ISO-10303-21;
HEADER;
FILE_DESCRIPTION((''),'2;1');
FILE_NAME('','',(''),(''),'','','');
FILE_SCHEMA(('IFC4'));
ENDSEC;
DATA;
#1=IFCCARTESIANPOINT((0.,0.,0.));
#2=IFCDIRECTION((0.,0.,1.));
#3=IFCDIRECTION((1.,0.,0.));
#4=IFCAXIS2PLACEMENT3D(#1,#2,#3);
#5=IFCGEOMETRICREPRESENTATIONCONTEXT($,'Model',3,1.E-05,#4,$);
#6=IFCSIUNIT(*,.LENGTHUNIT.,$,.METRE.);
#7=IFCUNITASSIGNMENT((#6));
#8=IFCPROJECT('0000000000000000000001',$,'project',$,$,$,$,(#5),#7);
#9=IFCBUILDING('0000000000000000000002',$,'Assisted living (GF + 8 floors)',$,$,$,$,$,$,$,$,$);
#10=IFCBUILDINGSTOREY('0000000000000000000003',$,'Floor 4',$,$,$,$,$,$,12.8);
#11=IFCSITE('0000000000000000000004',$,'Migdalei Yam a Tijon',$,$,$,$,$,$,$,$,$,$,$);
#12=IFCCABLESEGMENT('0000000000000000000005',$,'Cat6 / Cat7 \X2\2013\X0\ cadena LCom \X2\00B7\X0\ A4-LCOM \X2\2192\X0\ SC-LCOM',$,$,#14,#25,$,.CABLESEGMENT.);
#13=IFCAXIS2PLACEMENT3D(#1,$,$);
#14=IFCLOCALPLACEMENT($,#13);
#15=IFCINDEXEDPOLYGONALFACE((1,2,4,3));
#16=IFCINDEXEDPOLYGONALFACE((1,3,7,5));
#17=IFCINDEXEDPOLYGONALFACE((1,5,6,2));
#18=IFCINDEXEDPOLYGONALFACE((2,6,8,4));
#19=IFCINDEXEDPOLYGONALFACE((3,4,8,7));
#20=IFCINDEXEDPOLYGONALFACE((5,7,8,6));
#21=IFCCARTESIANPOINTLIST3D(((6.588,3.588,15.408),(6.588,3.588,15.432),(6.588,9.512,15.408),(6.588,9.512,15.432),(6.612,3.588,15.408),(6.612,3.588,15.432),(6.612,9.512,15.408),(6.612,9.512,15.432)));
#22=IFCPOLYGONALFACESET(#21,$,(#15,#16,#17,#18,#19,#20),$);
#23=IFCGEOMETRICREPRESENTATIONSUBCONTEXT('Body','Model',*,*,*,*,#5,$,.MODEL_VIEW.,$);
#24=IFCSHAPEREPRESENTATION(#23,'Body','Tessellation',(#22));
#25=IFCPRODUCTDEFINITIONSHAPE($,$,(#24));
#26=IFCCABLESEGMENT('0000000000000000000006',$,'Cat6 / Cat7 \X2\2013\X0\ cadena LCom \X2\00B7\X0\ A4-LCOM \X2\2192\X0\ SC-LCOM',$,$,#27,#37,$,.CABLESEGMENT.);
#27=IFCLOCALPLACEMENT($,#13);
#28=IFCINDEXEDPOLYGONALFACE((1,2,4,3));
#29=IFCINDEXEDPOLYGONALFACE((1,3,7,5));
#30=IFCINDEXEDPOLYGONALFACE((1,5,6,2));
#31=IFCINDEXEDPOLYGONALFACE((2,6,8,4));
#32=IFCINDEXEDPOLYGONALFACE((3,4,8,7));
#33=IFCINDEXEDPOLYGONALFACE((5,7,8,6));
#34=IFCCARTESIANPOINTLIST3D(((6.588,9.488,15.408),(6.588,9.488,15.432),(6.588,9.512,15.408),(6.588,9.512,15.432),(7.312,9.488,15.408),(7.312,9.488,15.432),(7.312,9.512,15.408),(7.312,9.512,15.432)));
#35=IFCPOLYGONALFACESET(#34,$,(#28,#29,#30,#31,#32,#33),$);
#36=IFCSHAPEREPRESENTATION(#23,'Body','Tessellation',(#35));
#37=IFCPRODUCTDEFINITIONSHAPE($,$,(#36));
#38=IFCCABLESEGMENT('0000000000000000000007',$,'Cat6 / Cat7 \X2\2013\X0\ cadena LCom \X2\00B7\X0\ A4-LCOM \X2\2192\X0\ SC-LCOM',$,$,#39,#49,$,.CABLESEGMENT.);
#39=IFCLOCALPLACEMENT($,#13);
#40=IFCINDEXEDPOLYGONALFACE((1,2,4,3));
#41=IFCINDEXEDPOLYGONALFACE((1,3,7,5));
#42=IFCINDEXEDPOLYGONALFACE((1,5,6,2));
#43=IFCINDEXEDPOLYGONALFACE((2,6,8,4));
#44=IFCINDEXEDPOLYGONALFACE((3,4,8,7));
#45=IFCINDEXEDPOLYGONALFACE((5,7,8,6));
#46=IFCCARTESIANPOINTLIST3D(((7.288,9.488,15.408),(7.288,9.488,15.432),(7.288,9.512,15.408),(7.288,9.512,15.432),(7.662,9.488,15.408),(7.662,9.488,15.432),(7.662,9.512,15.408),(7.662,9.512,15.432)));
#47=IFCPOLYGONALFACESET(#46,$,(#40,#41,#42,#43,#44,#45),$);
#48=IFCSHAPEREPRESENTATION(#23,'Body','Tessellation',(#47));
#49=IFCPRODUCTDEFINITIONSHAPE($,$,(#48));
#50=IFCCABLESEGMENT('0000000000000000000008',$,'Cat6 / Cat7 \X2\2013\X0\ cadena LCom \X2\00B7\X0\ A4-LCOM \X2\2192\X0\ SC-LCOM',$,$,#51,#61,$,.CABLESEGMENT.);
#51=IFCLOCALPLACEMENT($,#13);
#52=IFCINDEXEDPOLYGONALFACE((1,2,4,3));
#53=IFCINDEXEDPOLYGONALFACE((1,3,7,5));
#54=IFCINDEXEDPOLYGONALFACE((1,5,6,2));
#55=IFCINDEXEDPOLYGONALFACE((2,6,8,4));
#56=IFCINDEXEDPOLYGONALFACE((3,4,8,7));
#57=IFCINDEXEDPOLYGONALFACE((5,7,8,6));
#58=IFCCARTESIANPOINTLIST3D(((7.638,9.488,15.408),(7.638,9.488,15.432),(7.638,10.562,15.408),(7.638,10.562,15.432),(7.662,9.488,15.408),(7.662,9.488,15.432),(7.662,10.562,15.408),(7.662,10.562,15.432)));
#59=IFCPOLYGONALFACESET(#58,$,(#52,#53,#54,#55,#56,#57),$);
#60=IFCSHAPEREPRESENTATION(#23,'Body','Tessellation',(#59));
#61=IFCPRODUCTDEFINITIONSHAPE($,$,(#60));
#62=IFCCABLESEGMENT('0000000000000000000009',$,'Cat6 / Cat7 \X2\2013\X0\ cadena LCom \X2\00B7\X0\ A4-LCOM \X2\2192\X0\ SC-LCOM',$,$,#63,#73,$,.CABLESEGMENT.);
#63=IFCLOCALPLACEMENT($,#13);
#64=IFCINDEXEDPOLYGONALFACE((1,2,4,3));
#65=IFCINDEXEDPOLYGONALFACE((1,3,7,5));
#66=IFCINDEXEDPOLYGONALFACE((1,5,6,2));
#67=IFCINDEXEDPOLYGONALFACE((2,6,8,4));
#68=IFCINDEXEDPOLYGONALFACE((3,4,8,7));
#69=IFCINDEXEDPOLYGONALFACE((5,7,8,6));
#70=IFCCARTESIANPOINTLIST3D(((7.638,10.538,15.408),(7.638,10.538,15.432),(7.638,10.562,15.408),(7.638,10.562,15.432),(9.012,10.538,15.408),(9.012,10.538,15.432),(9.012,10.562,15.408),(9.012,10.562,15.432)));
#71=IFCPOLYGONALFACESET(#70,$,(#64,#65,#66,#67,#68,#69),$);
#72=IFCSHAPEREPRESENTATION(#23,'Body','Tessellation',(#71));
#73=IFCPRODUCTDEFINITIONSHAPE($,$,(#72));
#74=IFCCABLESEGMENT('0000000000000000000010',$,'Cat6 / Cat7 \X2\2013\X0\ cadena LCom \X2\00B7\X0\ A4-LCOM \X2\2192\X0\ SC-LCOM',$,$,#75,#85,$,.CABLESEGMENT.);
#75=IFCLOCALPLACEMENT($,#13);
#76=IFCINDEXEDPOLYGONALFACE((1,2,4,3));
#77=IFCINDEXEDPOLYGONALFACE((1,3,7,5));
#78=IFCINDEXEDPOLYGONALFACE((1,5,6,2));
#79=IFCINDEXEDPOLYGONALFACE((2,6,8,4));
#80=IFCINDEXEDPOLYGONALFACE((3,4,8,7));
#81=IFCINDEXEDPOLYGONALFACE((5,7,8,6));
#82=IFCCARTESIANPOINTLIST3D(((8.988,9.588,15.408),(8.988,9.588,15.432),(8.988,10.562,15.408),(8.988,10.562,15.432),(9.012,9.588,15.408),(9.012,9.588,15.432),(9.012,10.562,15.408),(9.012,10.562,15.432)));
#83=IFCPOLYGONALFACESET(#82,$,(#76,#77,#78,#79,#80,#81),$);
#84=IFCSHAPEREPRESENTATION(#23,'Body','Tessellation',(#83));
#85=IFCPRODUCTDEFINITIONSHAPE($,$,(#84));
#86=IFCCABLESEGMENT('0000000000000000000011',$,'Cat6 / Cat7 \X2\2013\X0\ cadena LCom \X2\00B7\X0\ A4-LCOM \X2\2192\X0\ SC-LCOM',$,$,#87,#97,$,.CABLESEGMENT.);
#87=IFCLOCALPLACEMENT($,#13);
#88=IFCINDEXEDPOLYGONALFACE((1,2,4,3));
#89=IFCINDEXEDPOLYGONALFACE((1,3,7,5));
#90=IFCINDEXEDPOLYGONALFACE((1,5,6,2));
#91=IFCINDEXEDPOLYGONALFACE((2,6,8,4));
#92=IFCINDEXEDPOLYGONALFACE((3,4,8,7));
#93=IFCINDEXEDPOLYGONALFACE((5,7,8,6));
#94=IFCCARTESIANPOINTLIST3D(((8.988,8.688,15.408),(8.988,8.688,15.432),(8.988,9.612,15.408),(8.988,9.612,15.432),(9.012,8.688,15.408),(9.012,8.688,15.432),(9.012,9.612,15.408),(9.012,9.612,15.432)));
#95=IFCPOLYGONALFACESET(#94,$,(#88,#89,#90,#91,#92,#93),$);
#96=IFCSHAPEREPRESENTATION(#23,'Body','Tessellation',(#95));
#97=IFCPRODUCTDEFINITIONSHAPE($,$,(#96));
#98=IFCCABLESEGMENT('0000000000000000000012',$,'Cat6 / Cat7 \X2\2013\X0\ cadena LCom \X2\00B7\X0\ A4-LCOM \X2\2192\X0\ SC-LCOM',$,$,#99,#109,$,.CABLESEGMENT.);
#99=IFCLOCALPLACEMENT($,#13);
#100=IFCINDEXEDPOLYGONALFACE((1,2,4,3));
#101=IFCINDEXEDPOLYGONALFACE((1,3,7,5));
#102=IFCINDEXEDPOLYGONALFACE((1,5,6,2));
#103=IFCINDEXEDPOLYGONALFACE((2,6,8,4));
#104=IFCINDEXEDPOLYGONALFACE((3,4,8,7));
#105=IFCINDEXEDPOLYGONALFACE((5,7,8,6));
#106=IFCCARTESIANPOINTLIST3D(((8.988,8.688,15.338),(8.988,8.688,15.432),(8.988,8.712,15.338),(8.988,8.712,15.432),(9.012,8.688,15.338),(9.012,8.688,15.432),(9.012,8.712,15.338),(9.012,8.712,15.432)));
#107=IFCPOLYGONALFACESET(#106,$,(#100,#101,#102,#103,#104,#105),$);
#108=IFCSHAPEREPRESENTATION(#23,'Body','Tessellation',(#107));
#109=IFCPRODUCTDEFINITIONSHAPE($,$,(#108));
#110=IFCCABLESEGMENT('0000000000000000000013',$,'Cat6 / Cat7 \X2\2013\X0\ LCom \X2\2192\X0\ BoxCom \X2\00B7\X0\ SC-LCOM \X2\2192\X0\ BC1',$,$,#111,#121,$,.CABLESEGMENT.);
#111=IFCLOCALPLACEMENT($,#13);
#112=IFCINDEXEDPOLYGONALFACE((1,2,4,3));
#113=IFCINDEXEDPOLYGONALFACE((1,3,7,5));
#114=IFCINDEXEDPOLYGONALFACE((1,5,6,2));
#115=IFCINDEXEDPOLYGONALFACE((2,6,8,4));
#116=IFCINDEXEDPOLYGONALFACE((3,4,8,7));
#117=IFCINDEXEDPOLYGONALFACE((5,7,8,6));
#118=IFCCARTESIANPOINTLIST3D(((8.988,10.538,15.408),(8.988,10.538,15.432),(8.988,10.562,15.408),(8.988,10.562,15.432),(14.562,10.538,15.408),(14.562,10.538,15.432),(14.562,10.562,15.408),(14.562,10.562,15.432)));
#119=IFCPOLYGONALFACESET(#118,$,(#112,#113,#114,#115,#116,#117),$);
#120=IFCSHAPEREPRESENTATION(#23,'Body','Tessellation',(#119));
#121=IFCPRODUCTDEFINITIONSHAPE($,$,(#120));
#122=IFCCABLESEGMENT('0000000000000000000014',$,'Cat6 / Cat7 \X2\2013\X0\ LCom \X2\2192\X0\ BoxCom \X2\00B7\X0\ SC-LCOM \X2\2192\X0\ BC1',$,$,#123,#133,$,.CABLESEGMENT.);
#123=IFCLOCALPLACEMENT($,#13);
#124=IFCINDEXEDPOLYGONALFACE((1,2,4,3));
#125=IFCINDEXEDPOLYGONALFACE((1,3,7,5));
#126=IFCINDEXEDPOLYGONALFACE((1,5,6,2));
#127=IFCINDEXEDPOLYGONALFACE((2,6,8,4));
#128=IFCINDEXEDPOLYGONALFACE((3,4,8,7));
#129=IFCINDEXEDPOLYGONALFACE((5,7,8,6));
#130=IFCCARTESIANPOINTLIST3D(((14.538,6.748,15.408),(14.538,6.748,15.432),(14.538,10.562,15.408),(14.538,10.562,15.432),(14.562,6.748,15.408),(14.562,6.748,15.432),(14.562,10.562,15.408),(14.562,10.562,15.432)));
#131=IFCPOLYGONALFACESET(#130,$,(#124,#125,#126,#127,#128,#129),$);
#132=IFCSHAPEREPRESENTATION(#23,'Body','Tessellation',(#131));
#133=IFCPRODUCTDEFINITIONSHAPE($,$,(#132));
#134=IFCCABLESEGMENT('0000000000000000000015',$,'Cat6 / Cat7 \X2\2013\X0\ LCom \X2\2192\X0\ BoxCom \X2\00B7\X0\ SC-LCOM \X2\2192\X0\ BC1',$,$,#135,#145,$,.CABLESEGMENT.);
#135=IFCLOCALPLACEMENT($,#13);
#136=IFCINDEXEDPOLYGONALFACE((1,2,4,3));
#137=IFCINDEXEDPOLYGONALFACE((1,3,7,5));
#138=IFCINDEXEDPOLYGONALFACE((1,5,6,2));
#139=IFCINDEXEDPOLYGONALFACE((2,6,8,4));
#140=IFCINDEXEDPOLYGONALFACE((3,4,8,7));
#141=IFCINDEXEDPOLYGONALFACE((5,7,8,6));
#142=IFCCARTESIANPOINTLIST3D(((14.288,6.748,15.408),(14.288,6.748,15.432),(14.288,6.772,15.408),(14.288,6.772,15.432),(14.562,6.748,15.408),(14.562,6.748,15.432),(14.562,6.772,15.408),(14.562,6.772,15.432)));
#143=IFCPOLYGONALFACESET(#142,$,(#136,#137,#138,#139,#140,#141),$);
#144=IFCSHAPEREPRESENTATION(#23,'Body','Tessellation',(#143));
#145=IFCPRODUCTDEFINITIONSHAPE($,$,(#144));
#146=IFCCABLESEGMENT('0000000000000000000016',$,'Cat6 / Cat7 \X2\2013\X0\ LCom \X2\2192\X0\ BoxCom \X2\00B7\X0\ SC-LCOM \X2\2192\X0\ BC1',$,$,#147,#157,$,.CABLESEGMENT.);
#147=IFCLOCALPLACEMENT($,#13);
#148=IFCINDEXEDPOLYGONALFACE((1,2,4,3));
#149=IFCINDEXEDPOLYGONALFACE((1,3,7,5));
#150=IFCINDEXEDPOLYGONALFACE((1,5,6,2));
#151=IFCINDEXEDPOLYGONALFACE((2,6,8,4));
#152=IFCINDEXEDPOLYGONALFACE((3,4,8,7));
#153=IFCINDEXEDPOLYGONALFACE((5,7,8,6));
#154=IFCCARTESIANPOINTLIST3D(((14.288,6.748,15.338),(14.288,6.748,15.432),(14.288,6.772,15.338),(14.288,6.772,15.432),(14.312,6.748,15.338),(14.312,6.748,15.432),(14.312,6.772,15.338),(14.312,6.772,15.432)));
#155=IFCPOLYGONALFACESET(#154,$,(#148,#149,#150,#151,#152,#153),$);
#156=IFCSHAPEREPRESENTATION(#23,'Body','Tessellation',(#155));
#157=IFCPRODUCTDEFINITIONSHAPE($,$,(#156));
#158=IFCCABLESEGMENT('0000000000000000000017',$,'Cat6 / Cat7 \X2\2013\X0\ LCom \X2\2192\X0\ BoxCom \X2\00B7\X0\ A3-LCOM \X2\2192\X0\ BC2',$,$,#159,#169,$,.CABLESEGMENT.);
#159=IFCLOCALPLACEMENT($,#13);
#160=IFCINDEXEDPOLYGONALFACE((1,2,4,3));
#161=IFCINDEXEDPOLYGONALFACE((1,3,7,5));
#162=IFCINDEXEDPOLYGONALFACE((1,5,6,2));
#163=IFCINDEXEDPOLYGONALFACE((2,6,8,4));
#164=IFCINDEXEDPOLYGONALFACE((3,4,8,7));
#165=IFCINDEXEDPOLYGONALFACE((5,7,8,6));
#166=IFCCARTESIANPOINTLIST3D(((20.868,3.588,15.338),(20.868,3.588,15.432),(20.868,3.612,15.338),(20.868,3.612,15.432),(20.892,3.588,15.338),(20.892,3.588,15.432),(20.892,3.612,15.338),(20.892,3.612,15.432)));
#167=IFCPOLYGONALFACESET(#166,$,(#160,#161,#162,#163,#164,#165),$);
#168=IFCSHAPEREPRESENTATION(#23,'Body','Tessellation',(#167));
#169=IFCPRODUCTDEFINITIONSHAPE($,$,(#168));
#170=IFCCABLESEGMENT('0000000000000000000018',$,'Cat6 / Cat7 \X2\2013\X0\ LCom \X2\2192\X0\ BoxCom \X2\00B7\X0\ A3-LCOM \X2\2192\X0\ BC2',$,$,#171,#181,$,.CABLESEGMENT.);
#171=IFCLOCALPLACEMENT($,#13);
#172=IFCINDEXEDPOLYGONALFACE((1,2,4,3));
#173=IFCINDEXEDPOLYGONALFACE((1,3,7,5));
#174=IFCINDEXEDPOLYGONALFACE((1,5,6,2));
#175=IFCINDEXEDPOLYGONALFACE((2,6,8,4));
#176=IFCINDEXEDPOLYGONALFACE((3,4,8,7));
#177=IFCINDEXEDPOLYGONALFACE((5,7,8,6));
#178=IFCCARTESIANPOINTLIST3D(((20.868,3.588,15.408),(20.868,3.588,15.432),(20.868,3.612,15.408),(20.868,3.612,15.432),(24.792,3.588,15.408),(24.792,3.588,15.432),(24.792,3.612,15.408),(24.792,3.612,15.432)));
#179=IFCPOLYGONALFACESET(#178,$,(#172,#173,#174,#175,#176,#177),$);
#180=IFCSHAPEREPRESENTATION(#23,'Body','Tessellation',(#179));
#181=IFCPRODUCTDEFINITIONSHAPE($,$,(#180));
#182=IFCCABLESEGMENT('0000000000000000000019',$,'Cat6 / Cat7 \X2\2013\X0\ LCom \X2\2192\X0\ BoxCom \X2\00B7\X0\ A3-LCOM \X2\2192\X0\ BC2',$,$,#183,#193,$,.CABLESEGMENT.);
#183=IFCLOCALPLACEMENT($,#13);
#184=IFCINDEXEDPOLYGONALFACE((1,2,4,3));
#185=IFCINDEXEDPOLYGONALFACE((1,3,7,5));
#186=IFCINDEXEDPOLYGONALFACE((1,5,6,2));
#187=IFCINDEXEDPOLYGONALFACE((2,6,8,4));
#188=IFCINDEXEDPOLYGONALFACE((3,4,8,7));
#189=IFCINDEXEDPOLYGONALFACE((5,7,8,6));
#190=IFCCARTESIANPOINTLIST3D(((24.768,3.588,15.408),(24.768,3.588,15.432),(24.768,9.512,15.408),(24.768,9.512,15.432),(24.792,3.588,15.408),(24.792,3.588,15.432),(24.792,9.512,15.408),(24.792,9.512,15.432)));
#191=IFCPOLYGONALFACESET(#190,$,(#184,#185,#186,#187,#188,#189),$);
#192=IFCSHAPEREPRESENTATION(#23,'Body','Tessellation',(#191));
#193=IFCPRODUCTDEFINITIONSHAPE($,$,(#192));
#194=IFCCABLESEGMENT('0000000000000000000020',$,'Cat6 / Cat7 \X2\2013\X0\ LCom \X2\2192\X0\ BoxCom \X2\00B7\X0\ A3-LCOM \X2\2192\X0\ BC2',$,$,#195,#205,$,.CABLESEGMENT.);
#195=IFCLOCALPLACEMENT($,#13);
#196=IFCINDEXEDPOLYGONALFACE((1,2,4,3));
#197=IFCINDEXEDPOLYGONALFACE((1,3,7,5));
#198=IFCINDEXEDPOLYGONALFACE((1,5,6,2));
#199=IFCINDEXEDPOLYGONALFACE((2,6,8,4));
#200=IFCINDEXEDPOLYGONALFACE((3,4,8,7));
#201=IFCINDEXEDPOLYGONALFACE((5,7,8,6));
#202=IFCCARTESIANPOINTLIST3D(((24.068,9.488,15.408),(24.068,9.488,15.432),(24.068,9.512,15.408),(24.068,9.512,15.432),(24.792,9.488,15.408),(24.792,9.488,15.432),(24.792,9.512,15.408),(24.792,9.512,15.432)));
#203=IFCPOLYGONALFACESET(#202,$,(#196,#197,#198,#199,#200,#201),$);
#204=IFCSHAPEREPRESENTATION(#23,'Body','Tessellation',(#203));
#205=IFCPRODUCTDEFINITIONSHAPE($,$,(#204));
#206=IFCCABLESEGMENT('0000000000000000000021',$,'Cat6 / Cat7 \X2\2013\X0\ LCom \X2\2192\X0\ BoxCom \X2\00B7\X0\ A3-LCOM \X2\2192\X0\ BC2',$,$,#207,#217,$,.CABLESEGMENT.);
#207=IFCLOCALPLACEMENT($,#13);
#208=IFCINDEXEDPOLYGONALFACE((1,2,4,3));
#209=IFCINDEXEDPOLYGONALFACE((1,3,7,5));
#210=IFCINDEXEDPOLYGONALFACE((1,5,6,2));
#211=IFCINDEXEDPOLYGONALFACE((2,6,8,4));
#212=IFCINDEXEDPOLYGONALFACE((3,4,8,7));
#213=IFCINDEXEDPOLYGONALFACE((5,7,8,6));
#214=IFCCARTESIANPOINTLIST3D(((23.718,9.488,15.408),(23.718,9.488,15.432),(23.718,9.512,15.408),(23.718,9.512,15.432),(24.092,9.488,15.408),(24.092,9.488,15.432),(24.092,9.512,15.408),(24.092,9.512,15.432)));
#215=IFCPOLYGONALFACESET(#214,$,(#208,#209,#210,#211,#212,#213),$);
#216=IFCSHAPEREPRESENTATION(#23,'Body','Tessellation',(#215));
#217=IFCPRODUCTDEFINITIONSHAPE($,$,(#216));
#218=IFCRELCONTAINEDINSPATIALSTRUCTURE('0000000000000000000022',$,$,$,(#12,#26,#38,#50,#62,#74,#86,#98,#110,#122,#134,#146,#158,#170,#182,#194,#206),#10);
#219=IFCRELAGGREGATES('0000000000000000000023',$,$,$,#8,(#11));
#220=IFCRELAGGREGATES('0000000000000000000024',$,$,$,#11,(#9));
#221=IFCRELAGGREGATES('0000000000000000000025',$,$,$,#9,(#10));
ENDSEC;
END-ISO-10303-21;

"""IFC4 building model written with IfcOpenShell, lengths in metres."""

from ifc_helpers import new_model, si_unit, frame, origin_with_axes, context, subcontext, project, spatial, line, indexed_curve, outline, extrude, element, save


model = new_model("IFC4")

# Units and contexts
model_context = context("Model", 3, precision=1e-05, world=origin_with_axes())
body_context = subcontext(model_context, "Body", "Model", "MODEL_VIEW")
ifc_project = project(units=[si_unit("LENGTHUNIT", "METRE")], contexts=[model_context])

# Site, building, storey
site = spatial("IfcSite", under=ifc_project, Name="Migdalei Yam a Tijon")
building = spatial("IfcBuilding", under=site, Name="Assisted living (GF + 8 floors)")
storey = spatial("IfcBuildingStorey", under=building, Name="Floor 4", Elevation=12.8)

# Cable segments
element("IfcCableSegment", 1, inside=storey, Name="Cat6 / Cat7 – cadena LCom · A4-LCOM → SC-LCOM", PredefinedType="CABLESEGMENT", context=body_context, shape_type="SweptSolid", body=[
    extrude(outline(indexed_curve([(0.0, 0.0), (0.024, 0.0), (0.024, 5.924), (0.0, 5.924)], segments=[line(1, 2, 3, 4, 1)])), frame((6.588, 3.588, 15.408), z_axis=(0.0, 0.0, 1.0), x_axis=(1.0, 0.0, 0.0)), (0.0, 0.0, 1.0), 0.024),
])
element("IfcCableSegment", 2, inside=storey, Name="Cat6 / Cat7 – cadena LCom · A4-LCOM → SC-LCOM", PredefinedType="CABLESEGMENT", context=body_context, shape_type="SweptSolid", body=[
    extrude(outline(indexed_curve([(0.0, 0.0), (0.724, 0.0), (0.724, 0.024), (0.0, 0.024)], segments=[line(1, 2, 3, 4, 1)])), frame((6.588, 9.488, 15.408), z_axis=(0.0, 0.0, 1.0), x_axis=(1.0, 0.0, 0.0)), (0.0, 0.0, 1.0), 0.024),
])
element("IfcCableSegment", 3, inside=storey, Name="Cat6 / Cat7 – cadena LCom · A4-LCOM → SC-LCOM", PredefinedType="CABLESEGMENT", context=body_context, shape_type="SweptSolid", body=[
    extrude(outline(indexed_curve([(0.0, 0.0), (0.374, 0.0), (0.374, 0.024), (0.0, 0.024)], segments=[line(1, 2, 3, 4, 1)])), frame((7.288, 9.488, 15.408), z_axis=(0.0, 0.0, 1.0), x_axis=(1.0, 0.0, 0.0)), (0.0, 0.0, 1.0), 0.024),
])
element("IfcCableSegment", 4, inside=storey, Name="Cat6 / Cat7 – cadena LCom · A4-LCOM → SC-LCOM", PredefinedType="CABLESEGMENT", context=body_context, shape_type="SweptSolid", body=[
    extrude(outline(indexed_curve([(0.0, 0.0), (0.024, 0.0), (0.024, 1.074), (0.0, 1.074)], segments=[line(1, 2, 3, 4, 1)])), frame((7.638, 9.488, 15.408), z_axis=(0.0, 0.0, 1.0), x_axis=(1.0, 0.0, 0.0)), (0.0, 0.0, 1.0), 0.024),
])
element("IfcCableSegment", 5, inside=storey, Name="Cat6 / Cat7 – cadena LCom · A4-LCOM → SC-LCOM", PredefinedType="CABLESEGMENT", context=body_context, shape_type="SweptSolid", body=[
    extrude(outline(indexed_curve([(0.0, 0.0), (1.374, 0.0), (1.374, 0.024), (0.0, 0.024)], segments=[line(1, 2, 3, 4, 1)])), frame((7.638, 10.538, 15.408), z_axis=(0.0, 0.0, 1.0), x_axis=(1.0, 0.0, 0.0)), (0.0, 0.0, 1.0), 0.024),
])
element("IfcCableSegment", 6, inside=storey, Name="Cat6 / Cat7 – cadena LCom · A4-LCOM → SC-LCOM", PredefinedType="CABLESEGMENT", context=body_context, shape_type="SweptSolid", body=[
    extrude(outline(indexed_curve([(0.0, 0.0), (0.024, 0.0), (0.024, 0.974), (0.0, 0.974)], segments=[line(1, 2, 3, 4, 1)])), frame((8.988, 9.588, 15.408), z_axis=(0.0, 0.0, 1.0), x_axis=(1.0, 0.0, 0.0)), (0.0, 0.0, 1.0), 0.024),
])
element("IfcCableSegment", 7, inside=storey, Name="Cat6 / Cat7 – cadena LCom · A4-LCOM → SC-LCOM", PredefinedType="CABLESEGMENT", context=body_context, shape_type="SweptSolid", body=[
    extrude(outline(indexed_curve([(0.0, 0.0), (0.024, 0.0), (0.024, 0.924), (0.0, 0.924)], segments=[line(1, 2, 3, 4, 1)])), frame((8.988, 8.688, 15.408), z_axis=(0.0, 0.0, 1.0), x_axis=(1.0, 0.0, 0.0)), (0.0, 0.0, 1.0), 0.024),
])
element("IfcCableSegment", 8, inside=storey, Name="Cat6 / Cat7 – cadena LCom · A4-LCOM → SC-LCOM", PredefinedType="CABLESEGMENT", context=body_context, shape_type="SweptSolid", body=[
    extrude(outline(indexed_curve([(0.0, 0.0), (0.024, 0.0), (0.024, 0.024), (0.0, 0.024)], segments=[line(1, 2, 3, 4, 1)])), frame((8.988, 8.688, 15.338), z_axis=(0.0, 0.0, 1.0), x_axis=(1.0, 0.0, 0.0)), (0.0, 0.0, 1.0), 0.094),
])
element("IfcCableSegment", 9, inside=storey, Name="Cat6 / Cat7 – LCom → BoxCom · SC-LCOM → BC1", PredefinedType="CABLESEGMENT", context=body_context, shape_type="SweptSolid", body=[
    extrude(outline(indexed_curve([(0.0, 0.0), (5.574, 0.0), (5.574, 0.024), (0.0, 0.024)], segments=[line(1, 2, 3, 4, 1)])), frame((8.988, 10.538, 15.408), z_axis=(0.0, 0.0, 1.0), x_axis=(1.0, 0.0, 0.0)), (0.0, 0.0, 1.0), 0.024),
])
element("IfcCableSegment", 10, inside=storey, Name="Cat6 / Cat7 – LCom → BoxCom · SC-LCOM → BC1", PredefinedType="CABLESEGMENT", context=body_context, shape_type="SweptSolid", body=[
    extrude(outline(indexed_curve([(0.0, 0.0), (0.024, 0.0), (0.024, 3.814), (0.0, 3.814)], segments=[line(1, 2, 3, 4, 1)])), frame((14.538, 6.748, 15.408), z_axis=(0.0, 0.0, 1.0), x_axis=(1.0, 0.0, 0.0)), (0.0, 0.0, 1.0), 0.024),
])
element("IfcCableSegment", 11, inside=storey, Name="Cat6 / Cat7 – LCom → BoxCom · SC-LCOM → BC1", PredefinedType="CABLESEGMENT", context=body_context, shape_type="SweptSolid", body=[
    extrude(outline(indexed_curve([(0.0, 0.0), (0.274, 0.0), (0.274, 0.024), (0.0, 0.024)], segments=[line(1, 2, 3, 4, 1)])), frame((14.288, 6.748, 15.408), z_axis=(0.0, 0.0, 1.0), x_axis=(1.0, 0.0, 0.0)), (0.0, 0.0, 1.0), 0.024),
])
element("IfcCableSegment", 12, inside=storey, Name="Cat6 / Cat7 – LCom → BoxCom · SC-LCOM → BC1", PredefinedType="CABLESEGMENT", context=body_context, shape_type="SweptSolid", body=[
    extrude(outline(indexed_curve([(0.0, 0.0), (0.024, 0.0), (0.024, 0.024), (0.0, 0.024)], segments=[line(1, 2, 3, 4, 1)])), frame((14.288, 6.748, 15.338), z_axis=(0.0, 0.0, 1.0), x_axis=(1.0, 0.0, 0.0)), (0.0, 0.0, 1.0), 0.094),
])
element("IfcCableSegment", 13, inside=storey, Name="Cat6 / Cat7 – LCom → BoxCom · A3-LCOM → BC2", PredefinedType="CABLESEGMENT", context=body_context, shape_type="SweptSolid", body=[
    extrude(outline(indexed_curve([(0.0, 0.0), (0.024, 0.0), (0.024, 0.024), (0.0, 0.024)], segments=[line(1, 2, 3, 4, 1)])), frame((20.868, 3.588, 15.338), z_axis=(0.0, 0.0, 1.0), x_axis=(1.0, 0.0, 0.0)), (0.0, 0.0, 1.0), 0.094),
])
element("IfcCableSegment", 14, inside=storey, Name="Cat6 / Cat7 – LCom → BoxCom · A3-LCOM → BC2", PredefinedType="CABLESEGMENT", context=body_context, shape_type="SweptSolid", body=[
    extrude(outline(indexed_curve([(0.0, 0.0), (3.924, 0.0), (3.924, 0.024), (0.0, 0.024)], segments=[line(1, 2, 3, 4, 1)])), frame((20.868, 3.588, 15.408), z_axis=(0.0, 0.0, 1.0), x_axis=(1.0, 0.0, 0.0)), (0.0, 0.0, 1.0), 0.024),
])
element("IfcCableSegment", 15, inside=storey, Name="Cat6 / Cat7 – LCom → BoxCom · A3-LCOM → BC2", PredefinedType="CABLESEGMENT", context=body_context, shape_type="SweptSolid", body=[
    extrude(outline(indexed_curve([(0.0, 0.0), (0.024, 0.0), (0.024, 5.924), (0.0, 5.924)], segments=[line(1, 2, 3, 4, 1)])), frame((24.768, 3.588, 15.408), z_axis=(0.0, 0.0, 1.0), x_axis=(1.0, 0.0, 0.0)), (0.0, 0.0, 1.0), 0.024),
])
element("IfcCableSegment", 16, inside=storey, Name="Cat6 / Cat7 – LCom → BoxCom · A3-LCOM → BC2", PredefinedType="CABLESEGMENT", context=body_context, shape_type="SweptSolid", body=[
    extrude(outline(indexed_curve([(0.0, 0.0), (0.724, 0.0), (0.724, 0.024), (0.0, 0.024)], segments=[line(1, 2, 3, 4, 1)])), frame((24.068, 9.488, 15.408), z_axis=(0.0, 0.0, 1.0), x_axis=(1.0, 0.0, 0.0)), (0.0, 0.0, 1.0), 0.024),
])
element("IfcCableSegment", 17, inside=storey, Name="Cat6 / Cat7 – LCom → BoxCom · A3-LCOM → BC2", PredefinedType="CABLESEGMENT", context=body_context, shape_type="SweptSolid", body=[
    extrude(outline(indexed_curve([(0.0, 0.0), (0.374, 0.0), (0.374, 0.024), (0.0, 0.024)], segments=[line(1, 2, 3, 4, 1)])), frame((23.718, 9.488, 15.408), z_axis=(0.0, 0.0, 1.0), x_axis=(1.0, 0.0, 0.0)), (0.0, 0.0, 1.0), 0.024),
])

save(model, "model.ifc")
